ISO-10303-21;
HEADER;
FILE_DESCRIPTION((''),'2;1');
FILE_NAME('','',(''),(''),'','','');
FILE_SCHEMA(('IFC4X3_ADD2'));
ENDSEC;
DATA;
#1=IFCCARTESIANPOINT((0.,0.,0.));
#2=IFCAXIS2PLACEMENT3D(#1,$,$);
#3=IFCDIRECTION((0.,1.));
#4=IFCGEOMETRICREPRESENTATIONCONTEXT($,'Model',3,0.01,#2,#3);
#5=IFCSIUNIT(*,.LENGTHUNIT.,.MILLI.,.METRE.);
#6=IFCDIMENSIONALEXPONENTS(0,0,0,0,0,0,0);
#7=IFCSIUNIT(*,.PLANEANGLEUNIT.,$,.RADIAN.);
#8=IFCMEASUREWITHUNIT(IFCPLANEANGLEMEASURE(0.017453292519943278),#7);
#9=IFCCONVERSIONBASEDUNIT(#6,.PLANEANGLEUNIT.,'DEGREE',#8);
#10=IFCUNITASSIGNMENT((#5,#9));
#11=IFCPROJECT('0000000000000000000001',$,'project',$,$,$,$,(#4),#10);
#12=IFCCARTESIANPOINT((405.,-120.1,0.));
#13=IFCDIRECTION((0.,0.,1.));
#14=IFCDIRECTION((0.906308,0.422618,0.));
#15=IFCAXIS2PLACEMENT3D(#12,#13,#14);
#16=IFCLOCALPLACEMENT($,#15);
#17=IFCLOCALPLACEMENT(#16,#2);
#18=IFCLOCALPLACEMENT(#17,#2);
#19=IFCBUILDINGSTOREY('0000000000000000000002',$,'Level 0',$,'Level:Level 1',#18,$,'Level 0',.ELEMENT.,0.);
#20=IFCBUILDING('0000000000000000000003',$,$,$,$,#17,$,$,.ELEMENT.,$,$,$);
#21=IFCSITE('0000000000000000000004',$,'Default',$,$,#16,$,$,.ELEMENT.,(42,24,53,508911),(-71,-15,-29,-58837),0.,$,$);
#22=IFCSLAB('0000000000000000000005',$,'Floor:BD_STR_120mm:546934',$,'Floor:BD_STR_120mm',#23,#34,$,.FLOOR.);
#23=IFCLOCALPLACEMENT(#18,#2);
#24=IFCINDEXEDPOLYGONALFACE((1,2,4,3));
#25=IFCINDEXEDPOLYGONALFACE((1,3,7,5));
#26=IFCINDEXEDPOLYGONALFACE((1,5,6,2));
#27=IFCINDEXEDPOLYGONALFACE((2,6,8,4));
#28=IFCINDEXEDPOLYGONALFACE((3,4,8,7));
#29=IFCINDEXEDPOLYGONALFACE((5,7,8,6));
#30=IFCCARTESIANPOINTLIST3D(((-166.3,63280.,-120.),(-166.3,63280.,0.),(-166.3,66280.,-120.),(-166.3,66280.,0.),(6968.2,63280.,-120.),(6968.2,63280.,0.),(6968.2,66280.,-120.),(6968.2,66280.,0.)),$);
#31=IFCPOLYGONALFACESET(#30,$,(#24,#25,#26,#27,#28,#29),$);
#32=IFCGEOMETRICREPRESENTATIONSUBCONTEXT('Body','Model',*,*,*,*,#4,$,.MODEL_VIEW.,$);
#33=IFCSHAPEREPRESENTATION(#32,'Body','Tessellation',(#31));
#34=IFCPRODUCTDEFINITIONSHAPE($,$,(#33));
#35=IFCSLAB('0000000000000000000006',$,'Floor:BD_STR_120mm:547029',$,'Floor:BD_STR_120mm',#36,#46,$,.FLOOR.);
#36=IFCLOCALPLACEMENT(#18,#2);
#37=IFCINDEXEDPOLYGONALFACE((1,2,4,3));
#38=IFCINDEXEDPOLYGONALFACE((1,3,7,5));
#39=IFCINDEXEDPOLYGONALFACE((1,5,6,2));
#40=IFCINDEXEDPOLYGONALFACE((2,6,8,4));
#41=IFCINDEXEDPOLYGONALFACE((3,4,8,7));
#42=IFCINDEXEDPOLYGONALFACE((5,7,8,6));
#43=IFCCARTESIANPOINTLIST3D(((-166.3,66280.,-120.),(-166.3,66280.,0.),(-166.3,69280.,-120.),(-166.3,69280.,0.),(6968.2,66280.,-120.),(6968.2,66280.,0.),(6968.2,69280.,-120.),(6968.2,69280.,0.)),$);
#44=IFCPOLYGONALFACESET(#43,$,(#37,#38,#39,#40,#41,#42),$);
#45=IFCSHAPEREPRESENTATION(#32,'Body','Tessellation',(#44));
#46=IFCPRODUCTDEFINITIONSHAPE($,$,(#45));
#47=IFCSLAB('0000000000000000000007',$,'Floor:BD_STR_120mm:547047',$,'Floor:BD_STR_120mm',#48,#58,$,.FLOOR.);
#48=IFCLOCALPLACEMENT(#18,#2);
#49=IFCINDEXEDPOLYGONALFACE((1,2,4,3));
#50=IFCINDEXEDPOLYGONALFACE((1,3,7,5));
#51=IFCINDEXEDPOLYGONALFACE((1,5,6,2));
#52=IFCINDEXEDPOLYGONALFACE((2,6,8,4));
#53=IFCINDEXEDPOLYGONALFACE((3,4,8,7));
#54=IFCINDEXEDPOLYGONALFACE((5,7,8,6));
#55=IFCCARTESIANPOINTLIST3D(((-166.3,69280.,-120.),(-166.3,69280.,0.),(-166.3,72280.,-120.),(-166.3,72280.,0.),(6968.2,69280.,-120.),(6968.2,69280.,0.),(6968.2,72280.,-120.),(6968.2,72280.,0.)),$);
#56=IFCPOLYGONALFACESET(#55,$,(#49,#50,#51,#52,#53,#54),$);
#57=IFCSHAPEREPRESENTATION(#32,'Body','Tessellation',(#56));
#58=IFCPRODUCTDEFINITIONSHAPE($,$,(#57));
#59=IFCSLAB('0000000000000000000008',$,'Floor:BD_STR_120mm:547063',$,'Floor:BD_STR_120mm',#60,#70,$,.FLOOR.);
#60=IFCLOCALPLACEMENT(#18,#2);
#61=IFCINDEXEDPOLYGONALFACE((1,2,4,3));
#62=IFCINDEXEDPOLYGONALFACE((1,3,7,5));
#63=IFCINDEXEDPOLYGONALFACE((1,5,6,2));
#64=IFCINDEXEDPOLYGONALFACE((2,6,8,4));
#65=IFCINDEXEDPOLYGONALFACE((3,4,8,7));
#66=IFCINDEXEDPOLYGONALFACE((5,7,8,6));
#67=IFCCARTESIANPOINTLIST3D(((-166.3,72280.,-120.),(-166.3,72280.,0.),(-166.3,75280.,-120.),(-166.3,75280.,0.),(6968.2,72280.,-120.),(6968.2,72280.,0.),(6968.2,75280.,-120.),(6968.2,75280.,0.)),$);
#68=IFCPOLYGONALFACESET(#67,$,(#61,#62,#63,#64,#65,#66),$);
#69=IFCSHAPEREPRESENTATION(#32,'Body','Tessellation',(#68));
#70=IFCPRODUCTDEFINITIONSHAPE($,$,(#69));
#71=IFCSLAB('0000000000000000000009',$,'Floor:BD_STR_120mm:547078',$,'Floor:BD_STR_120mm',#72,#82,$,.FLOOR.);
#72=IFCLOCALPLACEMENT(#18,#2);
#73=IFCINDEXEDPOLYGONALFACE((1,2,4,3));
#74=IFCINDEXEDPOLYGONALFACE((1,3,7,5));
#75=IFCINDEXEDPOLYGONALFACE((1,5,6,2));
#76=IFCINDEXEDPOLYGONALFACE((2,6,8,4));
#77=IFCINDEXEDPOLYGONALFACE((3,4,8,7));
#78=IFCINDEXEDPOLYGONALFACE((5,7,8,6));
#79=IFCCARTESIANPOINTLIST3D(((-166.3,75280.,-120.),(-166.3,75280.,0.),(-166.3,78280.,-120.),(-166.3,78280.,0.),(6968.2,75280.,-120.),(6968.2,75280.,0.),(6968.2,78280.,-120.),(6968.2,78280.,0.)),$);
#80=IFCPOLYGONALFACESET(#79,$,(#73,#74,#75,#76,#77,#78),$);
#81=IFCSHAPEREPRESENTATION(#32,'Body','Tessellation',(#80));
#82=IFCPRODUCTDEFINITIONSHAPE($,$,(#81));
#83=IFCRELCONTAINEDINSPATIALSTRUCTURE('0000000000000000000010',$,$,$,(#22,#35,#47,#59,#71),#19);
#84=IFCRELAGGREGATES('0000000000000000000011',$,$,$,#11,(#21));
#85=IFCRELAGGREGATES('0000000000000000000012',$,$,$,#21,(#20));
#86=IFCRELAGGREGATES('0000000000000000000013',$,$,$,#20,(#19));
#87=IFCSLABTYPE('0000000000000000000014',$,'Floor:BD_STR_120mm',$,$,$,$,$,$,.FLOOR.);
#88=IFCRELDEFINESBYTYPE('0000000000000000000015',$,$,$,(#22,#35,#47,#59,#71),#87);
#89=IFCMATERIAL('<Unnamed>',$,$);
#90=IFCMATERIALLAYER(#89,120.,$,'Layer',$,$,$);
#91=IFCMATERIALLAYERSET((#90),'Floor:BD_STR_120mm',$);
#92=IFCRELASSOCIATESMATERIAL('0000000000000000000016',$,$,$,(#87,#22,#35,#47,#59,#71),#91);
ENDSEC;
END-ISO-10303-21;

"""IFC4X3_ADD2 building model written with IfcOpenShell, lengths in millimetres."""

from ifc_helpers import new_model, entity, si_unit, converted_unit, direction, frame, frame_2d, origin, place, context, subcontext, project, spatial, rectangle, extrude, material, layer, layer_set, layer_usage, type_object, element, save


model = new_model("IFC4X3_ADD2")

# Units and contexts
model_context = context("Model", 3, precision=0.01, world=origin(), true_north=direction((0.0, 1.0)))
body_context = subcontext(model_context, "Body", "Model", "MODEL_VIEW")
ifc_project = project(units=[si_unit("LENGTHUNIT", "METRE", prefix="MILLI"), converted_unit("PLANEANGLEUNIT", "DEGREE", entity("IfcPlaneAngleMeasure", 0.017453292519943278), si_unit("PLANEANGLEUNIT", "RADIAN"), dimensions=[0, 0, 0, 0, 0, 0, 0])], contexts=[model_context])

# Site, building, storey
site_placement = place(None, frame((405.0, -120.1, 0.0), z_axis=(0.0, 0.0, 1.0), x_axis=(0.906308, 0.422618, 0.0)))
site = spatial("IfcSite", under=ifc_project, at=site_placement, Name="Default", CompositionType="ELEMENT", RefLatitude=(42, 24, 53, 508911), RefLongitude=(-71, -15, -29, -58837), RefElevation=0.0)
building_placement = place(site_placement, origin())
building = spatial("IfcBuilding", under=site, at=building_placement, CompositionType="ELEMENT")
storey_placement = place(building_placement, origin())
storey = spatial("IfcBuildingStorey", under=building, at=storey_placement, Name="Level 0", ObjectType="Level:Level 1", LongName="Level 0", CompositionType="ELEMENT", Elevation=0.0)

# Slabs
ifc_material = material(Name="<Unnamed>")
ifc_layer = layer(ifc_material, 120.0, Name="Layer")
ifc_layer_set = layer_set([ifc_layer], Name="Floor:BD_STR_120mm")
slab_type = type_object("IfcSlabType", Name="Floor:BD_STR_120mm", PredefinedType="FLOOR", material=ifc_layer_set)
ifc_layer_usage_1 = layer_usage(ifc_layer_set, "AXIS3", "POSITIVE", 0.0)
slab_1_placement = place(storey_placement, origin())
element("IfcSlab", 1, at=slab_1_placement, inside=storey, type_object=slab_type, material=ifc_layer_usage_1, Name="Floor:BD_STR_120mm:546934", ObjectType="Floor:BD_STR_120mm", PredefinedType="FLOOR", context=body_context, shape_type="SweptSolid", body=[
    extrude(rectangle(XDim=3000.0, YDim=7134.5, at=frame_2d((0.0, 0.0), x_axis=(1.0, 0.0))), frame((3401.0, 64780.0, 0.0), z_axis=(0.0, 0.0, -1.0), x_axis=(0.0, 1.0, 0.0)), (0.0, 0.0, 1.0), 120.0),
])
ifc_layer_usage_2 = layer_usage(ifc_layer_set, "AXIS3", "POSITIVE", 0.0)
slab_2_placement = place(storey_placement, origin())
element("IfcSlab", 2, at=slab_2_placement, inside=storey, type_object=slab_type, material=ifc_layer_usage_2, Name="Floor:BD_STR_120mm:547029", ObjectType="Floor:BD_STR_120mm", PredefinedType="FLOOR", context=body_context, shape_type="SweptSolid", body=[
    extrude(rectangle(XDim=3000.0, YDim=7134.5, at=frame_2d((0.0, 0.0), x_axis=(1.0, 0.0))), frame((3401.0, 67780.0, 0.0), z_axis=(0.0, 0.0, -1.0), x_axis=(0.0, 1.0, 0.0)), (0.0, 0.0, 1.0), 120.0),
])
ifc_layer_usage_3 = layer_usage(ifc_layer_set, "AXIS3", "POSITIVE", 0.0)
slab_3_placement = place(storey_placement, origin())
element("IfcSlab", 3, at=slab_3_placement, inside=storey, type_object=slab_type, material=ifc_layer_usage_3, Name="Floor:BD_STR_120mm:547047", ObjectType="Floor:BD_STR_120mm", PredefinedType="FLOOR", context=body_context, shape_type="SweptSolid", body=[
    extrude(rectangle(XDim=3000.0, YDim=7134.5, at=frame_2d((0.0, 0.0), x_axis=(1.0, 0.0))), frame((3401.0, 70780.0, 0.0), z_axis=(0.0, 0.0, -1.0), x_axis=(0.0, 1.0, 0.0)), (0.0, 0.0, 1.0), 120.0),
])
ifc_layer_usage_4 = layer_usage(ifc_layer_set, "AXIS3", "POSITIVE", 0.0)
slab_4_placement = place(storey_placement, origin())
element("IfcSlab", 4, at=slab_4_placement, inside=storey, type_object=slab_type, material=ifc_layer_usage_4, Name="Floor:BD_STR_120mm:547063", ObjectType="Floor:BD_STR_120mm", PredefinedType="FLOOR", context=body_context, shape_type="SweptSolid", body=[
    extrude(rectangle(XDim=3000.0, YDim=7134.5, at=frame_2d((0.0, 0.0), x_axis=(1.0, 0.0))), frame((3401.0, 73780.0, 0.0), z_axis=(0.0, 0.0, -1.0), x_axis=(0.0, 1.0, 0.0)), (0.0, 0.0, 1.0), 120.0),
])
ifc_layer_usage_5 = layer_usage(ifc_layer_set, "AXIS3", "POSITIVE", 0.0)
slab_5_placement = place(storey_placement, origin())
element("IfcSlab", 5, at=slab_5_placement, inside=storey, type_object=slab_type, material=ifc_layer_usage_5, Name="Floor:BD_STR_120mm:547078", ObjectType="Floor:BD_STR_120mm", PredefinedType="FLOOR", context=body_context, shape_type="SweptSolid", body=[
    extrude(rectangle(XDim=3000.0, YDim=7134.5, at=frame_2d((0.0, 0.0), x_axis=(1.0, 0.0))), frame((3401.0, 76780.0, 0.0), z_axis=(0.0, 0.0, -1.0), x_axis=(0.0, 1.0, 0.0)), (0.0, 0.0, 1.0), 120.0),
])

save(model, "model.ifc")
